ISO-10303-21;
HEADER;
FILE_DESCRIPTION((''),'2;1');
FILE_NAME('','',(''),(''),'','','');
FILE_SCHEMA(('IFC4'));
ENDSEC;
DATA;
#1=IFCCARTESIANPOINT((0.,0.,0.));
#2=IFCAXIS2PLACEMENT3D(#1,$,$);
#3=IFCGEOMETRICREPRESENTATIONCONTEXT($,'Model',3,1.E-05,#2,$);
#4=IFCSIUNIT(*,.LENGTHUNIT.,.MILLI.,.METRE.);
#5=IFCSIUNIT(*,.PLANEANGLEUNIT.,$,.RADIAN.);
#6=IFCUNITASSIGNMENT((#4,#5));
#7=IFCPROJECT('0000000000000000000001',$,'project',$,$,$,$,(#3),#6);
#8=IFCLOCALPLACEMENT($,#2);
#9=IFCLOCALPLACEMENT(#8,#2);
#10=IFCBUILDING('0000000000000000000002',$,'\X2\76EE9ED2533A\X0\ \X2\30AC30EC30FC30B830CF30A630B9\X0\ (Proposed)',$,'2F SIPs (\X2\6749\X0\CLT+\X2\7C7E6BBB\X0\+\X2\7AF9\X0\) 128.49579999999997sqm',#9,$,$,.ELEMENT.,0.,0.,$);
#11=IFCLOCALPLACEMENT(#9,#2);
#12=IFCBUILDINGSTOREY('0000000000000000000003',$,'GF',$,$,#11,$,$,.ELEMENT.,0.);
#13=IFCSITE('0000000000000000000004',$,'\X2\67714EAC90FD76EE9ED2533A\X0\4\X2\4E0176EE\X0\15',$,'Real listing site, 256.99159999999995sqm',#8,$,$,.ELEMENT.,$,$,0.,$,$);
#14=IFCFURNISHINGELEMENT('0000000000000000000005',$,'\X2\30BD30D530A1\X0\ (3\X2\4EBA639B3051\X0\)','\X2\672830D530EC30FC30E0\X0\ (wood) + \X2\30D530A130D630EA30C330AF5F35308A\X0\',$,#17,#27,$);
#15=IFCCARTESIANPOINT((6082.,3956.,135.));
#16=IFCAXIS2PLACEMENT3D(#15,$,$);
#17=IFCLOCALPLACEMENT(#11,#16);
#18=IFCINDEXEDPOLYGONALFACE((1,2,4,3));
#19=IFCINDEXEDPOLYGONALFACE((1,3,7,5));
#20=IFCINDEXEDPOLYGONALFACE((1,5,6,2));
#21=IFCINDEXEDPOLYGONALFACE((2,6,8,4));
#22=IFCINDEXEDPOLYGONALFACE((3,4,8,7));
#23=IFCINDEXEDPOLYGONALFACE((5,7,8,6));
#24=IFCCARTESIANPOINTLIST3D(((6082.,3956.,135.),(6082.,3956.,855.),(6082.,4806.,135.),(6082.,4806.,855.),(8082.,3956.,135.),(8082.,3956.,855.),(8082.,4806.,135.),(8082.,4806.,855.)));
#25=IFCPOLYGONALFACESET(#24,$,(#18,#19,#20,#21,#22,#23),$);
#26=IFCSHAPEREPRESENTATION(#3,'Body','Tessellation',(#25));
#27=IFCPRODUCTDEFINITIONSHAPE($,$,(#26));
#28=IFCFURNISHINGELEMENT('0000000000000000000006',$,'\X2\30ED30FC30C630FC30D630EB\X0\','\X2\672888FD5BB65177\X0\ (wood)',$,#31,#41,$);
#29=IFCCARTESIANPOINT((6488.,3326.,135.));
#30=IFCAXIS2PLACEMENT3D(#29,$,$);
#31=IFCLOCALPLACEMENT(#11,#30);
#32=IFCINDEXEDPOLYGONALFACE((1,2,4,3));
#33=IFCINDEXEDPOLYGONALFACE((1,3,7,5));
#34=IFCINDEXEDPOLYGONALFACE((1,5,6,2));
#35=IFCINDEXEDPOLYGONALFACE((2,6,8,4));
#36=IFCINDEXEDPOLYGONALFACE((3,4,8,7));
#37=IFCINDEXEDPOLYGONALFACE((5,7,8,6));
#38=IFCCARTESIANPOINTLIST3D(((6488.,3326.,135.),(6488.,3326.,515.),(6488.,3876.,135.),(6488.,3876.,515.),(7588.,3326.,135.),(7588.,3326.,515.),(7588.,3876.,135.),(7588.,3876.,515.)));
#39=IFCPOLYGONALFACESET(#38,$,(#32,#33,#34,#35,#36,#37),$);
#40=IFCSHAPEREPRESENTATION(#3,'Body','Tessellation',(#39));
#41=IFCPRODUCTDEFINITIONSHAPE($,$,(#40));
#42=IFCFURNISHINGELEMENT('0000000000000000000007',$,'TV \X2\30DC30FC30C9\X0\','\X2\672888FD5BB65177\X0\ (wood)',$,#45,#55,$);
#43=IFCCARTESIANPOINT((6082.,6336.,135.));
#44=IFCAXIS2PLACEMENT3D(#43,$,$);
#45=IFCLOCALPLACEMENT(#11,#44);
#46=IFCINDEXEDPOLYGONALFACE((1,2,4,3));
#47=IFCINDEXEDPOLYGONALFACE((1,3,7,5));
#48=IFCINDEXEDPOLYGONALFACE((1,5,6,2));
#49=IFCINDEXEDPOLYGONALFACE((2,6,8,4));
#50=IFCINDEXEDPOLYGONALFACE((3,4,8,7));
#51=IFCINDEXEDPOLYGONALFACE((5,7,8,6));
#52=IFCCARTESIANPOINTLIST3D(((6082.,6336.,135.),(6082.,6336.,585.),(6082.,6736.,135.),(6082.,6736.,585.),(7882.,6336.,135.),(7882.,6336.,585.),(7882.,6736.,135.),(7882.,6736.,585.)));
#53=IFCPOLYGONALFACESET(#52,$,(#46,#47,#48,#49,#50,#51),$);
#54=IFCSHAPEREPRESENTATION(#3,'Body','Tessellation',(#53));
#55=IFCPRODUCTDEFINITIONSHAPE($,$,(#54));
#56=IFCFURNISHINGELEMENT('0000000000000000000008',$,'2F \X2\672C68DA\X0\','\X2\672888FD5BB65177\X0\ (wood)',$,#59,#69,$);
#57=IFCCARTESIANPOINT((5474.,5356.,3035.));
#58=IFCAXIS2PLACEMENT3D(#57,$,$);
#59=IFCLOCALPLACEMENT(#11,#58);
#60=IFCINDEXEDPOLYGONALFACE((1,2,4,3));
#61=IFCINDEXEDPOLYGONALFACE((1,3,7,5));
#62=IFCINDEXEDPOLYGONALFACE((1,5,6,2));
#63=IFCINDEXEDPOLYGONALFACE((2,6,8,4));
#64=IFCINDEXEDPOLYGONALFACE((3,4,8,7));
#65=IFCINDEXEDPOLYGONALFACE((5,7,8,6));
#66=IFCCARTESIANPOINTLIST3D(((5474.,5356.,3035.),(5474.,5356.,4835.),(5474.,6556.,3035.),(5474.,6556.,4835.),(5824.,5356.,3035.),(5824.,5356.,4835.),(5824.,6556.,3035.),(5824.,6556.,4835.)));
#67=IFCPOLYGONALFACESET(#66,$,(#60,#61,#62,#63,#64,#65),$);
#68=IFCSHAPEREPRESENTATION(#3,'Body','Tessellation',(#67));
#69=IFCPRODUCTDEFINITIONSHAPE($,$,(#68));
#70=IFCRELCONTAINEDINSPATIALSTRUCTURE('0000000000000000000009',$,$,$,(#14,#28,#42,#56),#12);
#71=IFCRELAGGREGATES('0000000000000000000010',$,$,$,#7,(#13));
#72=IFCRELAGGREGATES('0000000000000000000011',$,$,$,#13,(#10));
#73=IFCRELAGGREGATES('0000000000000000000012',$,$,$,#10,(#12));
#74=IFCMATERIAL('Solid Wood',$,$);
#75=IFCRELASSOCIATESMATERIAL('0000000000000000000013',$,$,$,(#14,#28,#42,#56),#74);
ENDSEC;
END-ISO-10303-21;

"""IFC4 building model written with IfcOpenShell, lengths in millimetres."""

from ifc_helpers import new_model, si_unit, frame, frame_2d, origin, place, context, project, spatial, rectangle, extrude, material, element, save


model = new_model("IFC4")

# Units and contexts
model_context = context("Model", 3, precision=1e-05, world=origin())
ifc_project = project(units=[si_unit("LENGTHUNIT", "METRE", prefix="MILLI"), si_unit("PLANEANGLEUNIT", "RADIAN")], contexts=[model_context])

# Site, building, storey
site_placement = place(None, origin())
site = spatial("IfcSite", under=ifc_project, at=site_placement, Name="東京都目黒区4丁目15", ObjectType="Real listing site, 256.99159999999995sqm", CompositionType="ELEMENT", RefElevation=0.0)
building_placement = place(site_placement, origin())
building = spatial("IfcBuilding", under=site, at=building_placement, Name="目黒区 ガレージハウス (Proposed)", ObjectType="2F SIPs (杉CLT+籾殻+竹) 128.49579999999997sqm", CompositionType="ELEMENT", ElevationOfRefHeight=0.0, ElevationOfTerrain=0.0)
storey_placement = place(building_placement, origin())
storey = spatial("IfcBuildingStorey", under=building, at=storey_placement, Name="GF", CompositionType="ELEMENT", Elevation=0.0)

# Shared definitions
ifc_material_1 = material(Name="Solid Wood")

# Furnishing elements
furnishing_1_placement = place(storey_placement, frame((6082.0, 3956.0, 135.0)))
element("IfcFurnishingElement", 1, at=furnishing_1_placement, inside=storey, material=ifc_material_1, Name="ソファ (3人掛け)", Description="木フレーム (wood) + ファブリック張り", context=model_context, shape_type="SweptSolid", body=[
    extrude(rectangle(XDim=2000.0, YDim=850.0, at=frame_2d((1000.0, 425.0))), frame((6082.0, 3956.0, 135.0)), (0.0, 0.0, 1.0), 720.0),
])
furnishing_2_placement = place(storey_placement, frame((6488.0, 3326.0, 135.0)))
element("IfcFurnishingElement", 2, at=furnishing_2_placement, inside=storey, material=ifc_material_1, Name="ローテーブル", Description="木製家具 (wood)", context=model_context, shape_type="SweptSolid", body=[
    extrude(rectangle(XDim=1100.0, YDim=550.0, at=frame_2d((550.0, 275.0))), frame((6488.0, 3326.0, 135.0)), (0.0, 0.0, 1.0), 380.0),
])
furnishing_3_placement = place(storey_placement, frame((6082.0, 6336.0, 135.0)))
element("IfcFurnishingElement", 3, at=furnishing_3_placement, inside=storey, material=ifc_material_1, Name="TV ボード", Description="木製家具 (wood)", context=model_context, shape_type="SweptSolid", body=[
    extrude(rectangle(XDim=1800.0, YDim=400.0, at=frame_2d((900.0, 200.0))), frame((6082.0, 6336.0, 135.0)), (0.0, 0.0, 1.0), 450.0),
])
furnishing_4_placement = place(storey_placement, frame((5474.0, 5356.0, 3035.0)))
element("IfcFurnishingElement", 4, at=furnishing_4_placement, inside=storey, material=ifc_material_1, Name="2F 本棚", Description="木製家具 (wood)", context=model_context, shape_type="SweptSolid", body=[
    extrude(rectangle(XDim=350.0, YDim=1200.0, at=frame_2d((175.0, 600.0))), frame((5474.0, 5356.0, 3035.0)), (0.0, 0.0, 1.0), 1800.0),
])

save(model, "model.ifc")
